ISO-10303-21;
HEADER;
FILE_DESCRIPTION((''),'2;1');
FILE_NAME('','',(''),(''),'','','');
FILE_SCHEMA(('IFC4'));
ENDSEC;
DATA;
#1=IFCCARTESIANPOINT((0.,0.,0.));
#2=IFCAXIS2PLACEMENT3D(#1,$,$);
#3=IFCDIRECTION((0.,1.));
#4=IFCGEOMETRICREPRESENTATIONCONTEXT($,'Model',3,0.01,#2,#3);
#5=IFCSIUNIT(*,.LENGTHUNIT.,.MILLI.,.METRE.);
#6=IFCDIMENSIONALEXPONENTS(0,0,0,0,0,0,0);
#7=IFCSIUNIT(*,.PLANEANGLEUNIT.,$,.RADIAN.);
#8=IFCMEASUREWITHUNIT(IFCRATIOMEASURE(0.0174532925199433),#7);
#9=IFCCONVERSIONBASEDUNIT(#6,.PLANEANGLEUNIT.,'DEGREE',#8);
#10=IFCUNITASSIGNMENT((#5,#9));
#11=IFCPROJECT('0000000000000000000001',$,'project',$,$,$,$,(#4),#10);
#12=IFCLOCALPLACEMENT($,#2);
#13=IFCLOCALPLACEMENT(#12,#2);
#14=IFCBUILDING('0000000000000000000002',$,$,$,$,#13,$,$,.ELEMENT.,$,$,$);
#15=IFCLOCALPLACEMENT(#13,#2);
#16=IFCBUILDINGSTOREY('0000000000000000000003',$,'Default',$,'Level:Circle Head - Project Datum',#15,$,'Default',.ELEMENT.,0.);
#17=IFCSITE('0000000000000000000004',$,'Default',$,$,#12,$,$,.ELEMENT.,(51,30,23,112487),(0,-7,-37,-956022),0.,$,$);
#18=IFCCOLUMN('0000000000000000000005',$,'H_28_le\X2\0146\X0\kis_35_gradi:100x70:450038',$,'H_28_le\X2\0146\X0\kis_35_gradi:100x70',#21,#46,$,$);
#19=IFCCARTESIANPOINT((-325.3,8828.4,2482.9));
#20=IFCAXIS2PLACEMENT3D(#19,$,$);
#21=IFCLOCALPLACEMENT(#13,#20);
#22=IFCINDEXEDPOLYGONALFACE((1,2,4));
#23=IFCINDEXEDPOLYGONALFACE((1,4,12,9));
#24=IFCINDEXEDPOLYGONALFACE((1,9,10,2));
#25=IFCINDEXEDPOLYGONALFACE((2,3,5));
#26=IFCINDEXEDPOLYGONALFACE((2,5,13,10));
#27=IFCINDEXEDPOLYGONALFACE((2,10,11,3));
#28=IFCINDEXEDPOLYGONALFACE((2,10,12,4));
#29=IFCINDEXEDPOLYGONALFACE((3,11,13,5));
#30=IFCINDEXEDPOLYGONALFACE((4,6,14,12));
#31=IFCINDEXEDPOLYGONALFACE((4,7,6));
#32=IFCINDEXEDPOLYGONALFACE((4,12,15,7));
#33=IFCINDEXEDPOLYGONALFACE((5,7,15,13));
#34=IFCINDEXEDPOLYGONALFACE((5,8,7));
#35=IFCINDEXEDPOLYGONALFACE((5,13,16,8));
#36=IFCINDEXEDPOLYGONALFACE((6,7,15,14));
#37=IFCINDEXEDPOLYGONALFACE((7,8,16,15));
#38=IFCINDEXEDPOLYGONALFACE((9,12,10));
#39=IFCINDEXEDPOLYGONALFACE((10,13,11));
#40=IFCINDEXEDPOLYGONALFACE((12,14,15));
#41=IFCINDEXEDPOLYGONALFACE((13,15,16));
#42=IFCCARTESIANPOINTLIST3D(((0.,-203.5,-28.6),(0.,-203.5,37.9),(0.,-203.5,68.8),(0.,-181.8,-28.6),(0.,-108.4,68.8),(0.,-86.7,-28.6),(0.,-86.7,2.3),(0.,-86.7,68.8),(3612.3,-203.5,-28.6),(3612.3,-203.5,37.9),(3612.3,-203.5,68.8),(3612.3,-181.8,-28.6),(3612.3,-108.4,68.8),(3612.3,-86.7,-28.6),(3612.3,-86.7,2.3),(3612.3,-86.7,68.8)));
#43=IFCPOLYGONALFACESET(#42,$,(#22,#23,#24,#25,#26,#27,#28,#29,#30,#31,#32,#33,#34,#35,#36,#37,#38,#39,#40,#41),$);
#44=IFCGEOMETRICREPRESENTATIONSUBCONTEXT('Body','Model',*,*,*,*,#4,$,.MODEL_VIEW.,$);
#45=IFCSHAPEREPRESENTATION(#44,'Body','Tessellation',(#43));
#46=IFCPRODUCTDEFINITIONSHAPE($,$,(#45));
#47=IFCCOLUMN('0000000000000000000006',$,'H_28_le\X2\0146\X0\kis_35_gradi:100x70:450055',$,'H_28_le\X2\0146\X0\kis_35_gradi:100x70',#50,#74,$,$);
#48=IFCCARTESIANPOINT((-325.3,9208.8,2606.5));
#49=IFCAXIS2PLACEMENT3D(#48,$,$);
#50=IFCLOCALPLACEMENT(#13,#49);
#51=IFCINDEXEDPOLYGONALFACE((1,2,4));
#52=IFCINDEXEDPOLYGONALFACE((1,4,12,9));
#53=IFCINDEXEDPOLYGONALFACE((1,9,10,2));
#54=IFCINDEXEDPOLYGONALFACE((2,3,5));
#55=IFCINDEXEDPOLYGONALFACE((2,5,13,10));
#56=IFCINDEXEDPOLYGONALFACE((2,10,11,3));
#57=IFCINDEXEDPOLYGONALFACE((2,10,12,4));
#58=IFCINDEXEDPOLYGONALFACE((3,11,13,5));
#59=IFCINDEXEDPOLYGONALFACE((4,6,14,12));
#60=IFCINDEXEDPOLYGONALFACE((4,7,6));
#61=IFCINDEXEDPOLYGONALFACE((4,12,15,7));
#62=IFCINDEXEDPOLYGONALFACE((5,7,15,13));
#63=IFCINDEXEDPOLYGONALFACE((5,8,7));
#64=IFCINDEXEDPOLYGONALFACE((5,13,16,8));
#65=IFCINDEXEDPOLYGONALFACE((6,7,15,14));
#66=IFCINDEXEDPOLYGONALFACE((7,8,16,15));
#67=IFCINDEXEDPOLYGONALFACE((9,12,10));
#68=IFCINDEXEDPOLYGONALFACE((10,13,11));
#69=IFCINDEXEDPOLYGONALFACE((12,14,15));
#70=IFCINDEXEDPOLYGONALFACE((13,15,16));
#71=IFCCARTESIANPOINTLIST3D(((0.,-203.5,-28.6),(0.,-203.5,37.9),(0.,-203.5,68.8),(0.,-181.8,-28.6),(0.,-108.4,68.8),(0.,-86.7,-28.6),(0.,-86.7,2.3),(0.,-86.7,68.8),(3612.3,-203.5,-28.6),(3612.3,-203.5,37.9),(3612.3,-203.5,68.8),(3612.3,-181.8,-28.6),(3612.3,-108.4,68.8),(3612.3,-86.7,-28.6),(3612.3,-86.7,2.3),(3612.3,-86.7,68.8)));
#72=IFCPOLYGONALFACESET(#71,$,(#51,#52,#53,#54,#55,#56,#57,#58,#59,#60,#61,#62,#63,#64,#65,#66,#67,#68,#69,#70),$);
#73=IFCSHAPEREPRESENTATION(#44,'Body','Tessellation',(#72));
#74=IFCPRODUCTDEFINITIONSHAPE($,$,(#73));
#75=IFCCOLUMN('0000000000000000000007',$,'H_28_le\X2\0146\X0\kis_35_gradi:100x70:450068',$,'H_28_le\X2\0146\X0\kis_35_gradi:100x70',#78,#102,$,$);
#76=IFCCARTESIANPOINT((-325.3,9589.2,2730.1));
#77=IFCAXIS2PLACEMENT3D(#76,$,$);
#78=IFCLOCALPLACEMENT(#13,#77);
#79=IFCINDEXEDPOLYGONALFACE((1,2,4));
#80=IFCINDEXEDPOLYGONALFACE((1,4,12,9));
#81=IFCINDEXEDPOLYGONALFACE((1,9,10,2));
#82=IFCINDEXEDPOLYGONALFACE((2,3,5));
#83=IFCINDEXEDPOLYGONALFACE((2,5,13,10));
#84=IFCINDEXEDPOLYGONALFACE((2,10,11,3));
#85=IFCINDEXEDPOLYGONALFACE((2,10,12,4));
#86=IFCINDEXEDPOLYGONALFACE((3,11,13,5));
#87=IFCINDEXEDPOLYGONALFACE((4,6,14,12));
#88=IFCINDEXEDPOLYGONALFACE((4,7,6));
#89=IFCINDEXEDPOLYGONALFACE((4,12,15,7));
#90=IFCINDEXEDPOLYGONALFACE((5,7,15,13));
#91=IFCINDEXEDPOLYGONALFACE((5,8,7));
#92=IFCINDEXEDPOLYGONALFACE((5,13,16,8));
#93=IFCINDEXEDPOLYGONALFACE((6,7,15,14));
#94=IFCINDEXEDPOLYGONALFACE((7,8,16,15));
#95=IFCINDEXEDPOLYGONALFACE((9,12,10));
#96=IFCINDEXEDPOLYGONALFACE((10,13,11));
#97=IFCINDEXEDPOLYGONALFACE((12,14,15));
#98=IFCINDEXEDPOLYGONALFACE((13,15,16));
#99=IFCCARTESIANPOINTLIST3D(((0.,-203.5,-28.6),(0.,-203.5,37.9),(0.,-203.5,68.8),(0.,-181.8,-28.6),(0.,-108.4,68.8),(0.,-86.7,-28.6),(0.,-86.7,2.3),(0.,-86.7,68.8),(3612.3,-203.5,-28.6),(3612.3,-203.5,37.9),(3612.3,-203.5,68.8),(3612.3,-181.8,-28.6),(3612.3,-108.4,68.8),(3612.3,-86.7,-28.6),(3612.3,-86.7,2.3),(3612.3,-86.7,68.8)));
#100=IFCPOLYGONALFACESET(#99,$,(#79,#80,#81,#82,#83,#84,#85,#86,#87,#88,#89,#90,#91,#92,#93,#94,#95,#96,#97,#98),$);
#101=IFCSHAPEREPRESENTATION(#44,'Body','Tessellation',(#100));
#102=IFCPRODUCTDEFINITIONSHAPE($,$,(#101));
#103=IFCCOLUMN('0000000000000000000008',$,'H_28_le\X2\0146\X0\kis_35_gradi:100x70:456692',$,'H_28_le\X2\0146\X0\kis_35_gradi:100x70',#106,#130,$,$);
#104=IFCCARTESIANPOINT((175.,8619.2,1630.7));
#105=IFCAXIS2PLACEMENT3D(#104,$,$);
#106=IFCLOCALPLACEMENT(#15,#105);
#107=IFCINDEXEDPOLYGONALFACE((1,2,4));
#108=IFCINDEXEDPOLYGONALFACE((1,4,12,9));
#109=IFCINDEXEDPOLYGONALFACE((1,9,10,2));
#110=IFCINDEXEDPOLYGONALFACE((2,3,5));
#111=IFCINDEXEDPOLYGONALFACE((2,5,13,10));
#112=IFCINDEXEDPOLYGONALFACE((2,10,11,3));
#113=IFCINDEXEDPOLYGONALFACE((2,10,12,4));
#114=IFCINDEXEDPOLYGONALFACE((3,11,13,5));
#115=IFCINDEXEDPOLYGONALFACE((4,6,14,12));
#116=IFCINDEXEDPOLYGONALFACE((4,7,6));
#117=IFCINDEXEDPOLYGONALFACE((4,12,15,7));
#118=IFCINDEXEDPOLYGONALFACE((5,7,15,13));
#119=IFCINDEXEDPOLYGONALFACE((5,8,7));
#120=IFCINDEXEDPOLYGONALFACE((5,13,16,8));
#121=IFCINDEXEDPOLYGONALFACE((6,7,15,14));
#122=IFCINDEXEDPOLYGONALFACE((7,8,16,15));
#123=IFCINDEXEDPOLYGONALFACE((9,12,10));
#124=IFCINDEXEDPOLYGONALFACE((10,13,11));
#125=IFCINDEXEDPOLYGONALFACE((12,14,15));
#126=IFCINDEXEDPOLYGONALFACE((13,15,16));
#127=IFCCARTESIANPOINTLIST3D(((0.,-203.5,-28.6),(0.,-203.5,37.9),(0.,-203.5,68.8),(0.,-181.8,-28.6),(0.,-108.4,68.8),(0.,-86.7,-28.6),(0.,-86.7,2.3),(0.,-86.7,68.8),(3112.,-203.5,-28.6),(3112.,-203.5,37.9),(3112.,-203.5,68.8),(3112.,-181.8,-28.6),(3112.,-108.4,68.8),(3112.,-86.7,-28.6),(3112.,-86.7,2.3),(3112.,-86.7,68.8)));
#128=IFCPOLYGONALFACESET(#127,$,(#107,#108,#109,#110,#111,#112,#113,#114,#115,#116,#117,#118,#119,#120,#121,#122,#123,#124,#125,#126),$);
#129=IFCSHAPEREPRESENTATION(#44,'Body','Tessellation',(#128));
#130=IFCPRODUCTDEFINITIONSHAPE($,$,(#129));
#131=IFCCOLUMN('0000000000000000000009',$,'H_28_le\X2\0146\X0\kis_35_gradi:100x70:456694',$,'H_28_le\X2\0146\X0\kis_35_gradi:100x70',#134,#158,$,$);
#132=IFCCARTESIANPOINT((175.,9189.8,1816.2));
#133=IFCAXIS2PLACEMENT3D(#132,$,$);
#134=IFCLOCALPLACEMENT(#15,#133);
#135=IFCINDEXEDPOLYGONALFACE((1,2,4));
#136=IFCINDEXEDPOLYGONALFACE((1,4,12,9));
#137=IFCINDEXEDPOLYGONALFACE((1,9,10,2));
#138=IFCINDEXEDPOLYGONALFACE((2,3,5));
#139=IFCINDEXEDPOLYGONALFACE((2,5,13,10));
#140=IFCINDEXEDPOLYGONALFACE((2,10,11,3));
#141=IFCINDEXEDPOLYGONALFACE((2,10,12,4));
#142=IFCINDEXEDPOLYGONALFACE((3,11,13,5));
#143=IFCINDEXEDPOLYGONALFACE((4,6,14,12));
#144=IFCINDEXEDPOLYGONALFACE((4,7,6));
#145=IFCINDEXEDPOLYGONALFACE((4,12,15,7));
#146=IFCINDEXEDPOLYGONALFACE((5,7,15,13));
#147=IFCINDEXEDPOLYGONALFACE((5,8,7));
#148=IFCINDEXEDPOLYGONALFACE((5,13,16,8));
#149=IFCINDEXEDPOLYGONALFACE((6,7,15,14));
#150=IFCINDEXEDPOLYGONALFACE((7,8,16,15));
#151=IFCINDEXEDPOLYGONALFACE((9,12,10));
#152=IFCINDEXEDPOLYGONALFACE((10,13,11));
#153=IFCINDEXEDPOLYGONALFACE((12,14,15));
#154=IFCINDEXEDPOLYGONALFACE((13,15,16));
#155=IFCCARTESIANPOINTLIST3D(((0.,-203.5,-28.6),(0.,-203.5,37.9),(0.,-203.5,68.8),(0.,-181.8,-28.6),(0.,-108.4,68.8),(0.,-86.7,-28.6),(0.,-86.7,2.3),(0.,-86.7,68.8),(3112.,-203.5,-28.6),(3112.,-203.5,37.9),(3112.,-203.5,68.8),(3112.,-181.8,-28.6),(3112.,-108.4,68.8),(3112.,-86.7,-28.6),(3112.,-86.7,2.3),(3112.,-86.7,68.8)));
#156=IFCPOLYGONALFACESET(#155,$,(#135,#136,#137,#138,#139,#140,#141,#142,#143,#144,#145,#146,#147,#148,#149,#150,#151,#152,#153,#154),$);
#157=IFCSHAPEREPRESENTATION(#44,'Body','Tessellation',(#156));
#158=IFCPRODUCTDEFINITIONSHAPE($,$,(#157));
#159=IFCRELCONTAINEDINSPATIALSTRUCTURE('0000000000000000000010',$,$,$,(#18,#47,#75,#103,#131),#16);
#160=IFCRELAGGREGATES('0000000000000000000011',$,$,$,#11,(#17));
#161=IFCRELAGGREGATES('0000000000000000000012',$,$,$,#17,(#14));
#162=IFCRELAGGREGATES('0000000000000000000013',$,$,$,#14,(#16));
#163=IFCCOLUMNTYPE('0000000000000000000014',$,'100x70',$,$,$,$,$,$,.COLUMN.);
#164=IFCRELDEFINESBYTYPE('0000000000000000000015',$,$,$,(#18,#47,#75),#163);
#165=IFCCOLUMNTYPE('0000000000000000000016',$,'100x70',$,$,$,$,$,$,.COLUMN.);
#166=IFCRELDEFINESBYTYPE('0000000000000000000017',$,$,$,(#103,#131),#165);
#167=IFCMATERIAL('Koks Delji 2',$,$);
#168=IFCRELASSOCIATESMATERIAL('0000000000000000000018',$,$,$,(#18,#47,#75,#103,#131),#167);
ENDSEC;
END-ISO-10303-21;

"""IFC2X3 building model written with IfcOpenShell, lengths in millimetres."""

from ifc_helpers import new_model, entity, si_unit, converted_unit, direction, frame, frame_2d, origin, origin_2d_with_axis, place, context, subcontext, project, spatial, rectangle, extrude, boolean, source, transform, mapped, material, type_object, type_shapes, element, save


model = new_model("IFC2X3")

# Units and contexts
model_context = context("Model", 3, precision=0.01, world=origin(), true_north=direction((0.0, 1.0)))
body_context = subcontext(model_context, "Body", "Model", "MODEL_VIEW")
ifc_project = project(units=[si_unit("LENGTHUNIT", "METRE", prefix="MILLI"), converted_unit("PLANEANGLEUNIT", "DEGREE", entity("IfcRatioMeasure", 0.0174532925199433), si_unit("PLANEANGLEUNIT", "RADIAN"), dimensions=[0, 0, 0, 0, 0, 0, 0])], contexts=[model_context])

# Site, building, storey
site_placement = place(None, origin())
site = spatial("IfcSite", under=ifc_project, at=site_placement, Name="Default", CompositionType="ELEMENT", RefLatitude=(51, 30, 23, 112487), RefLongitude=(0, -7, -37, -956022), RefElevation=0.0)
building_placement = place(site_placement, origin())
building = spatial("IfcBuilding", under=site, at=building_placement, CompositionType="ELEMENT")
storey_placement = place(building_placement, origin())
storey = spatial("IfcBuildingStorey", under=building, at=storey_placement, Name="Default", ObjectType="Level:Circle Head - Project Datum", LongName="Default", CompositionType="ELEMENT", Elevation=0.0)

# Columns
ifc_material_1 = material(Name="Koks Delji 2")
column_type_1 = type_object("IfcColumnType", Name="100x70", PredefinedType="COLUMN")
shared_shape_1 = source(origin(), body_context, "Body", "CSG", [
    boolean("DIFFERENCE", extrude(rectangle(XDim=3612.3, YDim=116.7, at=origin_2d_with_axis()), frame((1806.1, -145.1, -28.6)), (0.0, 0.0, 1.0), 97.5), extrude(rectangle(XDim=70.0, YDim=100.0, at=frame_2d((0.0, 0.0), x_axis=(0.0, 1.0))), frame((0.0, -145.1, 20.1), z_axis=(-1.0, 0.0, 0.0), x_axis=(0.0, -0.951057, -0.309017)), (0.0, 0.0, -1.0), 3612.3)),
])
type_shapes(column_type_1, [shared_shape_1])
for number, where, name in (
    (1, (-325.3, 8828.4, 2482.9), "H_28_leņkis_35_gradi:100x70:450038"),
    (2, (-325.3, 9208.8, 2606.5), "H_28_leņkis_35_gradi:100x70:450055"),
    (3, (-325.3, 9589.2, 2730.1), "H_28_leņkis_35_gradi:100x70:450068"),
):
    element("IfcColumn", number, at=place(building_placement, frame(where)), inside=storey, type_object=column_type_1, material=ifc_material_1, Name=name, ObjectType="H_28_leņkis_35_gradi:100x70", context=body_context, shape_type="MappedRepresentation", body=[
        mapped(shared_shape_1, transform((0.0, 0.0, 0.0), scale=1.0)),
    ])
column_type_2 = type_object("IfcColumnType", Name="100x70", PredefinedType="COLUMN")
shared_shape_2 = source(origin(), body_context, "Body", "CSG", [
    boolean("DIFFERENCE", extrude(rectangle(XDim=3112.0, YDim=116.7, at=origin_2d_with_axis()), frame((1556.0, -145.1, -28.6)), (0.0, 0.0, 1.0), 97.5), extrude(rectangle(XDim=70.0, YDim=100.0, at=frame_2d((0.0, 0.0), x_axis=(0.0, 1.0))), frame((0.0, -145.1, 20.1), z_axis=(-1.0, 0.0, 0.0), x_axis=(0.0, -0.951057, -0.309017)), (0.0, 0.0, -1.0), 3112.0)),
])
type_shapes(column_type_2, [shared_shape_2])
for number, where, name in (
    (4, (175.0, 8619.2, 1630.7), "H_28_leņkis_35_gradi:100x70:456692"),
    (5, (175.0, 9189.8, 1816.2), "H_28_leņkis_35_gradi:100x70:456694"),
):
    element("IfcColumn", number, at=place(storey_placement, frame(where)), inside=storey, type_object=column_type_2, material=ifc_material_1, Name=name, ObjectType="H_28_leņkis_35_gradi:100x70", context=body_context, shape_type="MappedRepresentation", body=[
        mapped(shared_shape_2, transform((0.0, 0.0, 0.0), scale=1.0)),
    ])

save(model, "model.ifc")
